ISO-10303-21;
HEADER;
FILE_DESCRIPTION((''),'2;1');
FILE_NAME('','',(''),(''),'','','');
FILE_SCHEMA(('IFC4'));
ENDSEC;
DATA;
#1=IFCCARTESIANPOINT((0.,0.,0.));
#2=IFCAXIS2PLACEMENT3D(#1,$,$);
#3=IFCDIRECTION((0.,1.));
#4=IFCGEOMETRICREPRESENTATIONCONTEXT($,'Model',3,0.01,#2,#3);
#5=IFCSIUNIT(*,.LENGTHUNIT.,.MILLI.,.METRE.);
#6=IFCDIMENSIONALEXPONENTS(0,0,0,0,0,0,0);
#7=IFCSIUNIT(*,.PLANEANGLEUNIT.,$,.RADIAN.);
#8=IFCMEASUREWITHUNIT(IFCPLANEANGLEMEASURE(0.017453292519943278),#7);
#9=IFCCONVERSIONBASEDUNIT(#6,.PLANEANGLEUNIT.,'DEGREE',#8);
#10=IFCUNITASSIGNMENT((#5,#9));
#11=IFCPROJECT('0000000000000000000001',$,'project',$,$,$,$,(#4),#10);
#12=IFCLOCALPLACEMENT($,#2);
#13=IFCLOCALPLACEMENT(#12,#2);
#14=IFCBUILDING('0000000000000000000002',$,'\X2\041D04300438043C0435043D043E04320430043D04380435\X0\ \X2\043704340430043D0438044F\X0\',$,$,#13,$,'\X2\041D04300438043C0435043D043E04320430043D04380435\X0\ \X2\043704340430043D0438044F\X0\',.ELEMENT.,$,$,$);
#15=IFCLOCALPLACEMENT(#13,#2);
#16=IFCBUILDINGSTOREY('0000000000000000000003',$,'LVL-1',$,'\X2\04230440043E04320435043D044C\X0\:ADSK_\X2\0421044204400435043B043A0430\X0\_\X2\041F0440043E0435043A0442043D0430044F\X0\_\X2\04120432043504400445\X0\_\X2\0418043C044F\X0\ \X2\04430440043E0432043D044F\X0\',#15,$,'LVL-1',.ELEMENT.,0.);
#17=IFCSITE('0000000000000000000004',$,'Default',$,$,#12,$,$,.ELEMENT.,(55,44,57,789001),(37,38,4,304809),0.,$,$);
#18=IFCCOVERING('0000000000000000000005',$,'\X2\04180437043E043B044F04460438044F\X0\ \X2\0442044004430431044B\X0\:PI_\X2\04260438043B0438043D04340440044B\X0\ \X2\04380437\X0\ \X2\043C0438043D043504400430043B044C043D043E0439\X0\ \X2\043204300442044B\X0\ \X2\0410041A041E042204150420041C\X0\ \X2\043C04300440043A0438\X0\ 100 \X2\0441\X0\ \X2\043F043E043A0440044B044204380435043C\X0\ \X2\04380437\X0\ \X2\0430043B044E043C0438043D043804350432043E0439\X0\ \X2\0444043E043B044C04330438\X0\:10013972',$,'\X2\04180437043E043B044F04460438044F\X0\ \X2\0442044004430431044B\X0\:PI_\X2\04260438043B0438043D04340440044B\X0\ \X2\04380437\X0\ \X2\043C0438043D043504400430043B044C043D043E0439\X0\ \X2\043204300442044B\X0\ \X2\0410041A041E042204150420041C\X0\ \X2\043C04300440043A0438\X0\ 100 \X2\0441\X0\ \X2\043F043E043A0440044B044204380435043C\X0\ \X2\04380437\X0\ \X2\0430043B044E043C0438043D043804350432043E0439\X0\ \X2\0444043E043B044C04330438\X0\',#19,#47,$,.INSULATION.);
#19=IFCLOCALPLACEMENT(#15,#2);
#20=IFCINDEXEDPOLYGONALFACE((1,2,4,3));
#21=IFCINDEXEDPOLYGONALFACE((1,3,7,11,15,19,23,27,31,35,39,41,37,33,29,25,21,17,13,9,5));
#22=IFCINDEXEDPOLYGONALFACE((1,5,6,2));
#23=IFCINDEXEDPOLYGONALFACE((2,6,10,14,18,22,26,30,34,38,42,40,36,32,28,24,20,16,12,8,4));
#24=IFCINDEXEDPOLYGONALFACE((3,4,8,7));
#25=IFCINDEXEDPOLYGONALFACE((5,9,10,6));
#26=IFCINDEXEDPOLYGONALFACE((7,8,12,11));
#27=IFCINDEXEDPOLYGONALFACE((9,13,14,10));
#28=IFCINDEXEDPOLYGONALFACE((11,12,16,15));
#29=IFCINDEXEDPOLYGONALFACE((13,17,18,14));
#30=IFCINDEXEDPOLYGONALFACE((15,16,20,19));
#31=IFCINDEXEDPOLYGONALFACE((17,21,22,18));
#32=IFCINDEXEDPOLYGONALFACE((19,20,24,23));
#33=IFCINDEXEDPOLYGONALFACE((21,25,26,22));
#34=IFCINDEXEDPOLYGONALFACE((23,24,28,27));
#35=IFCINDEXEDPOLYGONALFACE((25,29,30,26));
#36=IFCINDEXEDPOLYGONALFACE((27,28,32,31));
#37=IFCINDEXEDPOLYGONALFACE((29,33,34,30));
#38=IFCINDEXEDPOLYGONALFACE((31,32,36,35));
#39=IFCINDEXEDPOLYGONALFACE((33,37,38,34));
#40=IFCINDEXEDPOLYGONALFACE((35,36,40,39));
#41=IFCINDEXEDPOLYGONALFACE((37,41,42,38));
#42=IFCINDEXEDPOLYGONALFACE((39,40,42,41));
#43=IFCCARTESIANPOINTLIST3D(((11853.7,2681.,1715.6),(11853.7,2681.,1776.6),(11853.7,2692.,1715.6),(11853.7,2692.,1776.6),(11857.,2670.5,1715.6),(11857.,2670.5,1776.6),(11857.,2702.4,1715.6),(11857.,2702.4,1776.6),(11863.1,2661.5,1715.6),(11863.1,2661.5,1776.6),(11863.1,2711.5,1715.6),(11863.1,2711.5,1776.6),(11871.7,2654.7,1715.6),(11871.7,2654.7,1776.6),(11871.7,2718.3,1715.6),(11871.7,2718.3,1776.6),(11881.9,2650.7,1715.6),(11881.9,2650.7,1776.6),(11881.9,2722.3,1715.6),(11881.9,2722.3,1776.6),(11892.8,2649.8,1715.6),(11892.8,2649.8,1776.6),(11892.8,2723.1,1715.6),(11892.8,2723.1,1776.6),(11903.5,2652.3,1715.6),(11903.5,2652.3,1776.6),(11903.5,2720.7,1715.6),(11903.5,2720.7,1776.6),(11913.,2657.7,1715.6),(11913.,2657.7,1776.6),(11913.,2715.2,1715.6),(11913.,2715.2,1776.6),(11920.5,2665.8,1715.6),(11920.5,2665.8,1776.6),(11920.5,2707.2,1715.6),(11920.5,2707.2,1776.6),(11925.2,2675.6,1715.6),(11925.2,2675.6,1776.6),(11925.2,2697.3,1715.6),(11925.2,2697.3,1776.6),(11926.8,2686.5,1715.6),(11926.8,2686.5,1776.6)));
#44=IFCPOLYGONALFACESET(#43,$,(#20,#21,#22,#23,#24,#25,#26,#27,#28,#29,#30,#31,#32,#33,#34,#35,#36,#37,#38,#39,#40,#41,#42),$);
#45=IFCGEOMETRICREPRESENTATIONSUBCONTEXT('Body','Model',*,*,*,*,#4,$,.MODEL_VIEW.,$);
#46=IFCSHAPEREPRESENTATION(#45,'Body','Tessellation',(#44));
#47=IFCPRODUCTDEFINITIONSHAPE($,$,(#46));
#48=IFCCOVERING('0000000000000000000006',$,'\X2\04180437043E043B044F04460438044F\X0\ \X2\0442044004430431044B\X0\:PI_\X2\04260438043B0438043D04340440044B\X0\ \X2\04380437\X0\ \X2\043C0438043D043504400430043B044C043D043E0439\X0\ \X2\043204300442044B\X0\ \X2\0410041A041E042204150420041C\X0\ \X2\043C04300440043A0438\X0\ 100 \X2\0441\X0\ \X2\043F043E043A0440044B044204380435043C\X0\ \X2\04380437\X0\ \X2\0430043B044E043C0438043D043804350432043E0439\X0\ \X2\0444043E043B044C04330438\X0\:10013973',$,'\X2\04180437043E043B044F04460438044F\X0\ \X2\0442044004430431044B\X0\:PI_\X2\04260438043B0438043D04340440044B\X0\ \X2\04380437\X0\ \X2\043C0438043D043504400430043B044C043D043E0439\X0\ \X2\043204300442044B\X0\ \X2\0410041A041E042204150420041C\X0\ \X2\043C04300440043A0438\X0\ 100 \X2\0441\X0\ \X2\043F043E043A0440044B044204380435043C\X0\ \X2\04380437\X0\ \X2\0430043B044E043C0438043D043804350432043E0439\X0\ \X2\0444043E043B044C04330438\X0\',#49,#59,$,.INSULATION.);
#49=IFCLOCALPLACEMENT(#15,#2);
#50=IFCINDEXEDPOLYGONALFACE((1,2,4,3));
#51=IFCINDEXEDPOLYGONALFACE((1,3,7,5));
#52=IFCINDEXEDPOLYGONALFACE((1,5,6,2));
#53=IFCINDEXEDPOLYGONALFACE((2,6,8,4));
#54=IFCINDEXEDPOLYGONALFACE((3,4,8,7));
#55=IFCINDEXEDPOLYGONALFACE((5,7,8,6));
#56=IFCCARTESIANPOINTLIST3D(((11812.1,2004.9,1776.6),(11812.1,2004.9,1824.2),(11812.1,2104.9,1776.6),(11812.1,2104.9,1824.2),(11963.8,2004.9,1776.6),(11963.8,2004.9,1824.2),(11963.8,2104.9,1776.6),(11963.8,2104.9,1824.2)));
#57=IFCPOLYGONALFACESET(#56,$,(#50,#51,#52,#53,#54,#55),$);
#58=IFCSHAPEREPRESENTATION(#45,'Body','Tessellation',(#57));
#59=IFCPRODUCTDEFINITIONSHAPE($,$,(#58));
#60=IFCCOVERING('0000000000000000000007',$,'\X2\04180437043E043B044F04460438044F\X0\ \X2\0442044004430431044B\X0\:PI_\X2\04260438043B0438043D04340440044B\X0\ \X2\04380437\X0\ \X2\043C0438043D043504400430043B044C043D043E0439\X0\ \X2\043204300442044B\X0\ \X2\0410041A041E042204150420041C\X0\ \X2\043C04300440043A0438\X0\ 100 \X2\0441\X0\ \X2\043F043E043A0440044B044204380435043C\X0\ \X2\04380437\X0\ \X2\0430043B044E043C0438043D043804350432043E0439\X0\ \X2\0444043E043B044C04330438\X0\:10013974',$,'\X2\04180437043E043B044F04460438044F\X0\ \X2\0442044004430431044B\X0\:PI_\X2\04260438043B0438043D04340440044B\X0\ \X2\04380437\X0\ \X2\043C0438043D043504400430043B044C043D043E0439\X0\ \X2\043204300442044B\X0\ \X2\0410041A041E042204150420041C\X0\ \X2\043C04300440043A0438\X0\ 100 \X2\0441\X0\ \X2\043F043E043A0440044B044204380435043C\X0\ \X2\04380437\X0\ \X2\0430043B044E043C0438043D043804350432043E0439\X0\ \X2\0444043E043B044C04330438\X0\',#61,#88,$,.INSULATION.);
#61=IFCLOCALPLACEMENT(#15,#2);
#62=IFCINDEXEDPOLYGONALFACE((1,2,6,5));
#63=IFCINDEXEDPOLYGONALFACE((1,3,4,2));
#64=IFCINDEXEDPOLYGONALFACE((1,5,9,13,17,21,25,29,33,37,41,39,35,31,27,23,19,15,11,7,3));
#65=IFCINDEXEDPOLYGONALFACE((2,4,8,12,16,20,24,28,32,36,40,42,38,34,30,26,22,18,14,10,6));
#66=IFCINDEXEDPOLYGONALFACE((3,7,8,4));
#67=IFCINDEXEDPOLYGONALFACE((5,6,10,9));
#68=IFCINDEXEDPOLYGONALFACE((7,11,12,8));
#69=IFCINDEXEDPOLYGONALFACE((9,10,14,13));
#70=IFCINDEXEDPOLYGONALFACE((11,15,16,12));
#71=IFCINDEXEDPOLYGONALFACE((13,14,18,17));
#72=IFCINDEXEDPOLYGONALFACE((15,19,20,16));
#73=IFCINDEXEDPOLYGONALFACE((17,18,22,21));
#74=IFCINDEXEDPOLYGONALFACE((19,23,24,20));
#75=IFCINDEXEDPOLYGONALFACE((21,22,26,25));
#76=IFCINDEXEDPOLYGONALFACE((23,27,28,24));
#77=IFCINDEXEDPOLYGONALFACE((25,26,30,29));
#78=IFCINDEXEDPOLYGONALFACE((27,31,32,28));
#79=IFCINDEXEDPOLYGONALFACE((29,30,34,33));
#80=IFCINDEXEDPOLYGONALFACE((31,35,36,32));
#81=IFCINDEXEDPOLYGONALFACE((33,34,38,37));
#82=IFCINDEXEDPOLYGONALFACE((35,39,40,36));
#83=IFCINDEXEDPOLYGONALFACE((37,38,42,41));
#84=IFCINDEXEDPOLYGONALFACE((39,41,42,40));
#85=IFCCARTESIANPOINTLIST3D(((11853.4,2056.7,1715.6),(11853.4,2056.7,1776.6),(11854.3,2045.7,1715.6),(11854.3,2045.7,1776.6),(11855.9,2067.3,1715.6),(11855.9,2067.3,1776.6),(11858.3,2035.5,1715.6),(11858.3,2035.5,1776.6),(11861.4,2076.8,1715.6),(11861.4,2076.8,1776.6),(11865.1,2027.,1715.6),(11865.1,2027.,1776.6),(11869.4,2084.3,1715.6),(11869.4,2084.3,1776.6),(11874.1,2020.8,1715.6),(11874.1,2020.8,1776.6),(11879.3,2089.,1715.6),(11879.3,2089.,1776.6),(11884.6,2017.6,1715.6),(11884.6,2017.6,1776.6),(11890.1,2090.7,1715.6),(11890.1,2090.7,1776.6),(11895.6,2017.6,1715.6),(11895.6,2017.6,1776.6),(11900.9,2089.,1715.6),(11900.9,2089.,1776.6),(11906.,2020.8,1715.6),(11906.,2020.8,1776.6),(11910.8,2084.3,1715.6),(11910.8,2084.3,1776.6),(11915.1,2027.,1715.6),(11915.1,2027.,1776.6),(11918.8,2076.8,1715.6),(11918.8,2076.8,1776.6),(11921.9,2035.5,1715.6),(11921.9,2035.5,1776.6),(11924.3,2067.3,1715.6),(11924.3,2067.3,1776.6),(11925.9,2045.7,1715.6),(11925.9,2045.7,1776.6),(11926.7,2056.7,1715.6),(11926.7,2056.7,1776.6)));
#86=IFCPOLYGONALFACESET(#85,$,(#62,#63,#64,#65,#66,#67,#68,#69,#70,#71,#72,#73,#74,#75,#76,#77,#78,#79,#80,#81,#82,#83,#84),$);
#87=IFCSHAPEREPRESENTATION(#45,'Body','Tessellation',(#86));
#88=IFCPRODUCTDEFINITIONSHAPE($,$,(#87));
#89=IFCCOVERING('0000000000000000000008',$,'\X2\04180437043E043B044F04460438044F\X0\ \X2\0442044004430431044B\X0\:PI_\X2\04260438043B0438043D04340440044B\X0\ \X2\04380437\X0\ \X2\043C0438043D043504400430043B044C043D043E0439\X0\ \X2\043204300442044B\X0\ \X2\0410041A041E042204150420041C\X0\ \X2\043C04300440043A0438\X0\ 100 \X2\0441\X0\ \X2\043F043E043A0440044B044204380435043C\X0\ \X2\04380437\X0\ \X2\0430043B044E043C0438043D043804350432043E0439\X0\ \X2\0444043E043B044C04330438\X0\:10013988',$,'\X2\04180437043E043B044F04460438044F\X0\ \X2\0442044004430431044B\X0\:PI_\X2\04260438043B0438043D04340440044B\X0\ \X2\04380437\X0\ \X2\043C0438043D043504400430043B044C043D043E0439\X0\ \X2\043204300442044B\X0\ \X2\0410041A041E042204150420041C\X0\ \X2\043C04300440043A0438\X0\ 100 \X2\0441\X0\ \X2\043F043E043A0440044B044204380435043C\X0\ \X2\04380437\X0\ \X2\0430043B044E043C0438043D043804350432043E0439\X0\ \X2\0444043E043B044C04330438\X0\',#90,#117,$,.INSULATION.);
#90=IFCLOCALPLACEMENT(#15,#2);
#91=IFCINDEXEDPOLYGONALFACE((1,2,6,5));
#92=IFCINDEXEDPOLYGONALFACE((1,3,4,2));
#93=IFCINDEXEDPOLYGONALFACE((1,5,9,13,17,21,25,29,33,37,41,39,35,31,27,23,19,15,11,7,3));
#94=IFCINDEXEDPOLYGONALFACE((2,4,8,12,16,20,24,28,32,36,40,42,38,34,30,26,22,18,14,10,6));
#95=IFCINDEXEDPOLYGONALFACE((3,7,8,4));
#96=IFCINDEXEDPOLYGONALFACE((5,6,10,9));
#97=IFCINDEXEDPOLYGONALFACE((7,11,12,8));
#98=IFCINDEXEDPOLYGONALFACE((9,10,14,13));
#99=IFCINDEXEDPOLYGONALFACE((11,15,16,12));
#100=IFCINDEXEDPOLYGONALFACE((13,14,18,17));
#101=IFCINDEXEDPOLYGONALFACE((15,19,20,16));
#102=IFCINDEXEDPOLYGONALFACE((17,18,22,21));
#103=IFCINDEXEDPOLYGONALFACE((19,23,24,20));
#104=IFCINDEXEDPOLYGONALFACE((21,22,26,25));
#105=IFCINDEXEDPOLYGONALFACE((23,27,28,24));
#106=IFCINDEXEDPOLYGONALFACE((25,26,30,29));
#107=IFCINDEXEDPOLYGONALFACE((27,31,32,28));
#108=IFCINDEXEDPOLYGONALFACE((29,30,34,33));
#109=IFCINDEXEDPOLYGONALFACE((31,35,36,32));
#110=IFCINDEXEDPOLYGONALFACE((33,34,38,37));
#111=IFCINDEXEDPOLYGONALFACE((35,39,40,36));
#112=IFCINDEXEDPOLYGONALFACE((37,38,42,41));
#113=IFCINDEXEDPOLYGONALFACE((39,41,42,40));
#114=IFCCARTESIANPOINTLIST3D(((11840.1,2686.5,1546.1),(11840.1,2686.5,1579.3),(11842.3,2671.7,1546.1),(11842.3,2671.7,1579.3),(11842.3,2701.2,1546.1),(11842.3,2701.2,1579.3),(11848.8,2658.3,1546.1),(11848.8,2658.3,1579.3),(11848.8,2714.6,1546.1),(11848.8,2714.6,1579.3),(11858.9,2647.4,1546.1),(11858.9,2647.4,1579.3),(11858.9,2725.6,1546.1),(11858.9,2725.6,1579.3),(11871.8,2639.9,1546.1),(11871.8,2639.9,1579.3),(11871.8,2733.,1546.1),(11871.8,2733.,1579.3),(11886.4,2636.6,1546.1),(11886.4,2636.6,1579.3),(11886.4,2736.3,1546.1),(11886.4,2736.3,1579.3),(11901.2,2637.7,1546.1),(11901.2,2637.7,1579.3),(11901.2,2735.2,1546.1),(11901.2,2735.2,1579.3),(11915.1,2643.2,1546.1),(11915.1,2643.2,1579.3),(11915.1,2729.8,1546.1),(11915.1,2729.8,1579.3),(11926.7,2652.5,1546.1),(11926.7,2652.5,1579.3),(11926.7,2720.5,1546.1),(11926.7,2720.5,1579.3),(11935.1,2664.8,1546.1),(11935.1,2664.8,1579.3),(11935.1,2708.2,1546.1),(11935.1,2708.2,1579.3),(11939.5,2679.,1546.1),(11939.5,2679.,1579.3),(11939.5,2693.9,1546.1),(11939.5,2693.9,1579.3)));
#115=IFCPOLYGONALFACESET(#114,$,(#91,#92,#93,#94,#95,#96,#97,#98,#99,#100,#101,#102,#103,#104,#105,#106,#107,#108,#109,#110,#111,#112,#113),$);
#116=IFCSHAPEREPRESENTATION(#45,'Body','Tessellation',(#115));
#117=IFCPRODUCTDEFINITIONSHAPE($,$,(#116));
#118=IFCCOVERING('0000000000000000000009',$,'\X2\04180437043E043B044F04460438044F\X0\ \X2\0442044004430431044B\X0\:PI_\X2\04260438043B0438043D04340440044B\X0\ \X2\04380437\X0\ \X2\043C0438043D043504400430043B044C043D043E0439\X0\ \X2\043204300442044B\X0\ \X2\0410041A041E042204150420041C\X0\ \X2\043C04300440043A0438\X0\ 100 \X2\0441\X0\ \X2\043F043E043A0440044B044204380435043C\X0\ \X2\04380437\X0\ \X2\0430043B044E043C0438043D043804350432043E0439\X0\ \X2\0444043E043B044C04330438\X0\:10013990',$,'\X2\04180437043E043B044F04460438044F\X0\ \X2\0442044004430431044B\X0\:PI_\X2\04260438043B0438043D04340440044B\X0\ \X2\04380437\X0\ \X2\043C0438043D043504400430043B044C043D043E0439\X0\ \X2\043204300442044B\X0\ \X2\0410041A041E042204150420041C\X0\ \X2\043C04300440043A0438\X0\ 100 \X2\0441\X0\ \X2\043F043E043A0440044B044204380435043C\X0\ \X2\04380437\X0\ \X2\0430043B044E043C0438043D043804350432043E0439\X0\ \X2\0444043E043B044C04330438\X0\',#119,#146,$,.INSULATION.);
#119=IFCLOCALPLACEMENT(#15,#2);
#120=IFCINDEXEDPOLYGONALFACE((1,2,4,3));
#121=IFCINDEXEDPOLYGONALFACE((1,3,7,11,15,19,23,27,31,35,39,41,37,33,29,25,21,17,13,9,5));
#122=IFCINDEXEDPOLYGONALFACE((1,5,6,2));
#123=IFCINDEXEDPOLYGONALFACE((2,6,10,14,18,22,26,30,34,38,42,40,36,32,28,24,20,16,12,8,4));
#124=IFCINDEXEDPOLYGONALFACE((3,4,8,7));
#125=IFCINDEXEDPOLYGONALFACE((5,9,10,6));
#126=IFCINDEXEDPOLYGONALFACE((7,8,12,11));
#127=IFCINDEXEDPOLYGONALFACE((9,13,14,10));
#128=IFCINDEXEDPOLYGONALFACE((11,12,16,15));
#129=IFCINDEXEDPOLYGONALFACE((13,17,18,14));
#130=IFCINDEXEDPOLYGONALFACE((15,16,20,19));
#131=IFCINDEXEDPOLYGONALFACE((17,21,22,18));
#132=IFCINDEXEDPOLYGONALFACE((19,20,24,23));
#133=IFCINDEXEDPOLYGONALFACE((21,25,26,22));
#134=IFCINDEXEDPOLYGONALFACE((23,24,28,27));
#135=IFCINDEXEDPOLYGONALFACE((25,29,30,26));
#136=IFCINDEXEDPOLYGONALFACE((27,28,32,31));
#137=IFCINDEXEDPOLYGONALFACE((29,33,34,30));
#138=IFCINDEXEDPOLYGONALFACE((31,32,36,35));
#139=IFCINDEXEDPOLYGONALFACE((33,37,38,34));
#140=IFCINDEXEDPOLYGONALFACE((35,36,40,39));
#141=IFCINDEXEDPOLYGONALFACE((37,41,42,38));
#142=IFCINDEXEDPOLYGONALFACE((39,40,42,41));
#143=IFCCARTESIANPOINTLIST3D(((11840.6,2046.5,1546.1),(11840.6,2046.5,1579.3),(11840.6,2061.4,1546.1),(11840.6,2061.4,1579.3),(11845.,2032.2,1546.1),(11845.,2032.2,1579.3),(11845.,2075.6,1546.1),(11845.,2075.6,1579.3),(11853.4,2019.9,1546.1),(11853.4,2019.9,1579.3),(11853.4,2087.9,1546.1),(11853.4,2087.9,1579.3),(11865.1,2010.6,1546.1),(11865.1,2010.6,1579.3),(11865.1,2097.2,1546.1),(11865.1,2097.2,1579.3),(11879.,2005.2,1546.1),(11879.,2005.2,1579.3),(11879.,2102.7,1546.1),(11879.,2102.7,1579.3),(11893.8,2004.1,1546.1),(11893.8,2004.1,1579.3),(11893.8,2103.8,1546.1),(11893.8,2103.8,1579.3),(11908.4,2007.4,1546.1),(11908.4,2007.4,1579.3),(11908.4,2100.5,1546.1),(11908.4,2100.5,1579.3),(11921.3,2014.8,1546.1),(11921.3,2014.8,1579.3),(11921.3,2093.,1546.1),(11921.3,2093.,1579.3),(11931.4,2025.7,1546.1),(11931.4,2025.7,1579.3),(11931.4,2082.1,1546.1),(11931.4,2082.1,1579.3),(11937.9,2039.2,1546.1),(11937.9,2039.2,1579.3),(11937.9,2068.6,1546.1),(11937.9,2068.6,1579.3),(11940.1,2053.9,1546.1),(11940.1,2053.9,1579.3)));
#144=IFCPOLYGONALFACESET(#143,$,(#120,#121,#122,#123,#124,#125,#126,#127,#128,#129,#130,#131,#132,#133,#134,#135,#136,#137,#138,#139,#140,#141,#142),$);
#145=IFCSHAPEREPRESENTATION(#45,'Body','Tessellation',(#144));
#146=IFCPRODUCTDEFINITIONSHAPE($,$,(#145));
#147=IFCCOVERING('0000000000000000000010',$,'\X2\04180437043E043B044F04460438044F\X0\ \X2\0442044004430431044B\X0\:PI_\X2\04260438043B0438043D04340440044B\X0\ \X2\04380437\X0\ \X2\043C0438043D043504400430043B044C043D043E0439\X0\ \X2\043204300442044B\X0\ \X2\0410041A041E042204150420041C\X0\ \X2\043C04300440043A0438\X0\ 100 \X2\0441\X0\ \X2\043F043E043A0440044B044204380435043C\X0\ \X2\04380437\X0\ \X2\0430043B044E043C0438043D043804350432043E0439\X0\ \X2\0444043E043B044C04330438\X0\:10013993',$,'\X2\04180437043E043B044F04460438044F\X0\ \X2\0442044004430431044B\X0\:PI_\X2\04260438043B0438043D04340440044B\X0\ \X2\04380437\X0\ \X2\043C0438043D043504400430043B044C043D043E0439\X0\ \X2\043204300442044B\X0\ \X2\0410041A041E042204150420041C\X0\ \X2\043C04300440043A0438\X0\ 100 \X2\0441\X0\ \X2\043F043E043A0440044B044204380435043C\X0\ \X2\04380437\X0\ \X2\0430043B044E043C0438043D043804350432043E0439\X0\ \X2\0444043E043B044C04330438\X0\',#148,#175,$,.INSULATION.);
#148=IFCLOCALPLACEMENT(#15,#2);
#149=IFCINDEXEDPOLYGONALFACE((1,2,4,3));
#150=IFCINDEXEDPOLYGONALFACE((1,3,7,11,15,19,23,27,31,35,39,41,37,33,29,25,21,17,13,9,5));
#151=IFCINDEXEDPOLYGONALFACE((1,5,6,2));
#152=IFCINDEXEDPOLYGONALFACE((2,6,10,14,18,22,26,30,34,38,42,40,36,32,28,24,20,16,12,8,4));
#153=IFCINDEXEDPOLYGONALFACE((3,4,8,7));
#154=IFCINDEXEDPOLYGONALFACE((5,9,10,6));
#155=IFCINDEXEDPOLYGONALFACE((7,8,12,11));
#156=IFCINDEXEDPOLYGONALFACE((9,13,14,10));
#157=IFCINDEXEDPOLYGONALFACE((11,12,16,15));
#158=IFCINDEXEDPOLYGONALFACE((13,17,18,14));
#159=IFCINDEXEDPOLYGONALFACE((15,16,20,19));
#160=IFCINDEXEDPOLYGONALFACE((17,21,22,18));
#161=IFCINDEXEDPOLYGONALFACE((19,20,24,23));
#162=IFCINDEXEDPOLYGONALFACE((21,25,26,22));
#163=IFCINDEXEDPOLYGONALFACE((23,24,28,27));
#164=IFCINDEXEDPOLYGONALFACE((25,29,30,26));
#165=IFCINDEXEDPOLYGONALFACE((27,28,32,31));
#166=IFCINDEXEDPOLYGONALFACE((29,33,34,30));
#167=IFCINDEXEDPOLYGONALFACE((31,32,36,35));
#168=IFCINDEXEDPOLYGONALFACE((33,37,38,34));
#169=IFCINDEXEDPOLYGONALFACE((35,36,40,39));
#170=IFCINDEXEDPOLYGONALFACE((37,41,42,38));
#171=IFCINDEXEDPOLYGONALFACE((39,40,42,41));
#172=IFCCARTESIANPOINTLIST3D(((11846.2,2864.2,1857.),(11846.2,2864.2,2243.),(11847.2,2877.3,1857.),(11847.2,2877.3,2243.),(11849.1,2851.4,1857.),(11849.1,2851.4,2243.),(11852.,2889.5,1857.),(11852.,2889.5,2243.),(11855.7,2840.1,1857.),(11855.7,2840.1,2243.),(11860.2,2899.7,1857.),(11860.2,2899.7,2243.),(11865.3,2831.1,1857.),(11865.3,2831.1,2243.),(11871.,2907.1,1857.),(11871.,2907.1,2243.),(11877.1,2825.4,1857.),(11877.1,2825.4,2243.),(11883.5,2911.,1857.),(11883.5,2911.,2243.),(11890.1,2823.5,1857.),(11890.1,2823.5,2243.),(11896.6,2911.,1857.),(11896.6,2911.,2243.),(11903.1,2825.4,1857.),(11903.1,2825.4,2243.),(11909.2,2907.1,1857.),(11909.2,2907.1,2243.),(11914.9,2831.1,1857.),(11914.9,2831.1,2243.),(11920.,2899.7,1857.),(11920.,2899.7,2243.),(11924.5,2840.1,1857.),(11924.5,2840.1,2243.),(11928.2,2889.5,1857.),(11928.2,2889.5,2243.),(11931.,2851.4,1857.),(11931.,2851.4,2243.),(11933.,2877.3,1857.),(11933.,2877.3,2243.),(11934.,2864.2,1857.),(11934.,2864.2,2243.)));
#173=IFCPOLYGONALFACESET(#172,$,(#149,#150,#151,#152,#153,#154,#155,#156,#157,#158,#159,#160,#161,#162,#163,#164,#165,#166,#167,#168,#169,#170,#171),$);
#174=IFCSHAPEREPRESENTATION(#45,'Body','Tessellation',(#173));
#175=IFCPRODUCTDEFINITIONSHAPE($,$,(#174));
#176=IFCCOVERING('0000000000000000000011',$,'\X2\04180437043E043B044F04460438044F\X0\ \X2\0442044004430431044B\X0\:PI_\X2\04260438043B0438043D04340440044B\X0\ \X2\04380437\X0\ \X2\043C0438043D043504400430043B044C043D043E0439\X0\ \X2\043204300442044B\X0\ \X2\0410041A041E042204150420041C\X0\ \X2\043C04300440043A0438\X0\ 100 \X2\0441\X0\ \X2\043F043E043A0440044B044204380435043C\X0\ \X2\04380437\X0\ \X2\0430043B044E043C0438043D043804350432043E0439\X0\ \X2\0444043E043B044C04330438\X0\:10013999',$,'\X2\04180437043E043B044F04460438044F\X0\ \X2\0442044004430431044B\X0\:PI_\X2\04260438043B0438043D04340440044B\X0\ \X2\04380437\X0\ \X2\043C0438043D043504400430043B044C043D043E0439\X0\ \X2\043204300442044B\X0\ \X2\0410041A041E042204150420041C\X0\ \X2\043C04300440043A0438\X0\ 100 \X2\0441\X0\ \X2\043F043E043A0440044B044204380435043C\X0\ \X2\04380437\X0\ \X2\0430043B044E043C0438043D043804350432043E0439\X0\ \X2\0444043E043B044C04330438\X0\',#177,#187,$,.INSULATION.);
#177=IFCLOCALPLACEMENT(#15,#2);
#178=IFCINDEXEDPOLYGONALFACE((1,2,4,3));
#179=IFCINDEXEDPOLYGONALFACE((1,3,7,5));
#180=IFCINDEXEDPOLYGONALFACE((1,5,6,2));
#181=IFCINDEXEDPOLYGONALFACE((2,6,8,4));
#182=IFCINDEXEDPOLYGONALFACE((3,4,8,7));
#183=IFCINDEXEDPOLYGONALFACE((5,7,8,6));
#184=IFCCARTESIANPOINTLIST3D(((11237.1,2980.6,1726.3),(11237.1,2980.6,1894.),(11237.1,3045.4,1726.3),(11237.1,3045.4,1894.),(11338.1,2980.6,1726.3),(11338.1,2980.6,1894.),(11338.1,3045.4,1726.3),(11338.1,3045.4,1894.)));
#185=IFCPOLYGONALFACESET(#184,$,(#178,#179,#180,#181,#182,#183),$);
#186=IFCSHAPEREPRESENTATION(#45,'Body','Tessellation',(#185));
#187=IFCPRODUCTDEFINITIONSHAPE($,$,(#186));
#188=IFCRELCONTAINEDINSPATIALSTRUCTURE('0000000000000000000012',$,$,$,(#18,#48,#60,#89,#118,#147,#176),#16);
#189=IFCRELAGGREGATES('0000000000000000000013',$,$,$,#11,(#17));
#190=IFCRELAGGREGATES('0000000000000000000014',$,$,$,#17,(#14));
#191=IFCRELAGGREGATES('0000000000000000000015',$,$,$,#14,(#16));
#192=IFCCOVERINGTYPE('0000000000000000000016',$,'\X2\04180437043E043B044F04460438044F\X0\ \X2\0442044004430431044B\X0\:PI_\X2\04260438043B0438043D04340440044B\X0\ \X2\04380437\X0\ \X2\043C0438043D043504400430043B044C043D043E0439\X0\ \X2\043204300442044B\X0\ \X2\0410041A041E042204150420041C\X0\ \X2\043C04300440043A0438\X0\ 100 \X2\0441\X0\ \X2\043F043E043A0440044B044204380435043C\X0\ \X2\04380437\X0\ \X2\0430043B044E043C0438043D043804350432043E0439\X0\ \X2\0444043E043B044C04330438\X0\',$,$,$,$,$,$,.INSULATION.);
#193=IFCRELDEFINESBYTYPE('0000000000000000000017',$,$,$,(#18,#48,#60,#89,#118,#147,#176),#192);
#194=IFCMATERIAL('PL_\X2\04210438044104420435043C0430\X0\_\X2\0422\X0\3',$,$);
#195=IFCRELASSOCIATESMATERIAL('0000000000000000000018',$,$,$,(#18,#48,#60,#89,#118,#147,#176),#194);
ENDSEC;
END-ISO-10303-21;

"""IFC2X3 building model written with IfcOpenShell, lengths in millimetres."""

from ifc_helpers import new_model, entity, si_unit, converted_unit, direction, frame, frame_2d, origin, origin_2d_with_axis, place, context, subcontext, project, spatial, rectangle, circle, extrude, material, type_object, element, save


model = new_model("IFC2X3")

# Units and contexts
model_context = context("Model", 3, precision=0.01, world=origin(), true_north=direction((0.0, 1.0)))
body_context = subcontext(model_context, "Body", "Model", "MODEL_VIEW")
ifc_project = project(units=[si_unit("LENGTHUNIT", "METRE", prefix="MILLI"), converted_unit("PLANEANGLEUNIT", "DEGREE", entity("IfcPlaneAngleMeasure", 0.017453292519943278), si_unit("PLANEANGLEUNIT", "RADIAN"), dimensions=[0, 0, 0, 0, 0, 0, 0])], contexts=[model_context])

# Site, building, storey
site_placement = place(None, origin())
site = spatial("IfcSite", under=ifc_project, at=site_placement, Name="Default", CompositionType="ELEMENT", RefLatitude=(55, 44, 57, 789001), RefLongitude=(37, 38, 4, 304809), RefElevation=0.0)
building_placement = place(site_placement, origin())
building = spatial("IfcBuilding", under=site, at=building_placement, Name="Наименование здания", LongName="Наименование здания", CompositionType="ELEMENT")
storey_placement = place(building_placement, origin())
storey = spatial("IfcBuildingStorey", under=building, at=storey_placement, Name="LVL-1", ObjectType="Уровень:ADSK_Стрелка_Проектная_Вверх_Имя уровня", LongName="LVL-1", CompositionType="ELEMENT", Elevation=0.0)

# Coverings
ifc_material_1 = material(Name="PL_Система_Т3")
covering_type = type_object("IfcCoveringType", Name="Изоляция трубы:PI_Цилиндры из минеральной ваты АКОТЕРМ марки 100 с покрытием из алюминиевой фольги", PredefinedType="INSULATION")
covering_1_placement = place(storey_placement, origin())
element("IfcCovering", 1, at=covering_1_placement, inside=storey, type_object=covering_type, material=ifc_material_1, Name="Изоляция трубы:PI_Цилиндры из минеральной ваты АКОТЕРМ марки 100 с покрытием из алюминиевой фольги:10013972", ObjectType="Изоляция трубы:PI_Цилиндры из минеральной ваты АКОТЕРМ марки 100 с покрытием из алюминиевой фольги", PredefinedType="INSULATION", context=body_context, shape_type="SweptSolid", body=[
    extrude(circle(Radius=36.8, at=origin_2d_with_axis()), frame((11890.1, 2686.5, 1715.6)), (0.0, 0.0, 1.0), 61.0),
])
covering_2_placement = place(storey_placement, origin())
element("IfcCovering", 2, at=covering_2_placement, inside=storey, type_object=covering_type, material=ifc_material_1, Name="Изоляция трубы:PI_Цилиндры из минеральной ваты АКОТЕРМ марки 100 с покрытием из алюминиевой фольги:10013973", ObjectType="Изоляция трубы:PI_Цилиндры из минеральной ваты АКОТЕРМ марки 100 с покрытием из алюминиевой фольги", PredefinedType="INSULATION", context=body_context, shape_type="SweptSolid", body=[
    extrude(rectangle(XDim=151.7, YDim=100.0, at=frame_2d((0.0, 0.0), x_axis=(1.0, 0.0))), frame((11888.0, 2054.9, 1776.6)), (0.0, 0.0, 1.0), 47.7),
])
covering_3_placement = place(storey_placement, origin())
element("IfcCovering", 3, at=covering_3_placement, inside=storey, type_object=covering_type, material=ifc_material_1, Name="Изоляция трубы:PI_Цилиндры из минеральной ваты АКОТЕРМ марки 100 с покрытием из алюминиевой фольги:10013974", ObjectType="Изоляция трубы:PI_Цилиндры из минеральной ваты АКОТЕРМ марки 100 с покрытием из алюминиевой фольги", PredefinedType="INSULATION", context=body_context, shape_type="SweptSolid", body=[
    extrude(circle(Radius=36.8, at=frame_2d((0.0, 0.0), x_axis=(1.0, 0.0))), frame((11890.1, 2053.9, 1715.6), z_axis=(0.0, 0.0, 1.0), x_axis=(0.0, 1.0, 0.0)), (0.0, 0.0, 1.0), 61.0),
])
covering_4_placement = place(storey_placement, origin())
element("IfcCovering", 4, at=covering_4_placement, inside=storey, type_object=covering_type, material=ifc_material_1, Name="Изоляция трубы:PI_Цилиндры из минеральной ваты АКОТЕРМ марки 100 с покрытием из алюминиевой фольги:10013988", ObjectType="Изоляция трубы:PI_Цилиндры из минеральной ваты АКОТЕРМ марки 100 с покрытием из алюминиевой фольги", PredefinedType="INSULATION", context=body_context, shape_type="SweptSolid", body=[
    extrude(circle(Radius=50.0, at=frame_2d((0.0, 0.0), x_axis=(1.0, 0.0))), frame((11890.1, 2686.5, 1546.1), z_axis=(0.0, 0.0, 1.0), x_axis=(-1.0, 0.0, 0.0)), (0.0, 0.0, 1.0), 33.2),
])
covering_5_placement = place(storey_placement, origin())
element("IfcCovering", 5, at=covering_5_placement, inside=storey, type_object=covering_type, material=ifc_material_1, Name="Изоляция трубы:PI_Цилиндры из минеральной ваты АКОТЕРМ марки 100 с покрытием из алюминиевой фольги:10013990", ObjectType="Изоляция трубы:PI_Цилиндры из минеральной ваты АКОТЕРМ марки 100 с покрытием из алюминиевой фольги", PredefinedType="INSULATION", context=body_context, shape_type="SweptSolid", body=[
    extrude(circle(Radius=50.0, at=frame_2d((0.0, 0.0), x_axis=(1.0, 0.0))), frame((11890.1, 2053.9, 1546.1)), (0.0, 0.0, 1.0), 33.2),
])
covering_6_placement = place(storey_placement, origin())
element("IfcCovering", 6, at=covering_6_placement, inside=storey, type_object=covering_type, material=ifc_material_1, Name="Изоляция трубы:PI_Цилиндры из минеральной ваты АКОТЕРМ марки 100 с покрытием из алюминиевой фольги:10013993", ObjectType="Изоляция трубы:PI_Цилиндры из минеральной ваты АКОТЕРМ марки 100 с покрытием из алюминиевой фольги", PredefinedType="INSULATION", context=body_context, shape_type="SweptSolid", body=[
    extrude(circle(Radius=44.0, at=origin_2d_with_axis()), frame((11890.1, 2867.5, 1857.0), z_axis=(0.0, 0.0, 1.0), x_axis=(0.0, -1.0, 0.0)), (0.0, 0.0, 1.0), 386.0),
])
covering_7_placement = place(storey_placement, origin())
element("IfcCovering", 7, at=covering_7_placement, inside=storey, type_object=covering_type, material=ifc_material_1, Name="Изоляция трубы:PI_Цилиндры из минеральной ваты АКОТЕРМ марки 100 с покрытием из алюминиевой фольги:10013999", ObjectType="Изоляция трубы:PI_Цилиндры из минеральной ваты АКОТЕРМ марки 100 с покрытием из алюминиевой фольги", PredefinedType="INSULATION", context=body_context, shape_type="SweptSolid", body=[
    extrude(rectangle(XDim=101.0, YDim=64.9, at=origin_2d_with_axis()), frame((11287.6, 3013.0, 1726.3)), (0.0, 0.0, 1.0), 167.7),
])

save(model, "model.ifc")
